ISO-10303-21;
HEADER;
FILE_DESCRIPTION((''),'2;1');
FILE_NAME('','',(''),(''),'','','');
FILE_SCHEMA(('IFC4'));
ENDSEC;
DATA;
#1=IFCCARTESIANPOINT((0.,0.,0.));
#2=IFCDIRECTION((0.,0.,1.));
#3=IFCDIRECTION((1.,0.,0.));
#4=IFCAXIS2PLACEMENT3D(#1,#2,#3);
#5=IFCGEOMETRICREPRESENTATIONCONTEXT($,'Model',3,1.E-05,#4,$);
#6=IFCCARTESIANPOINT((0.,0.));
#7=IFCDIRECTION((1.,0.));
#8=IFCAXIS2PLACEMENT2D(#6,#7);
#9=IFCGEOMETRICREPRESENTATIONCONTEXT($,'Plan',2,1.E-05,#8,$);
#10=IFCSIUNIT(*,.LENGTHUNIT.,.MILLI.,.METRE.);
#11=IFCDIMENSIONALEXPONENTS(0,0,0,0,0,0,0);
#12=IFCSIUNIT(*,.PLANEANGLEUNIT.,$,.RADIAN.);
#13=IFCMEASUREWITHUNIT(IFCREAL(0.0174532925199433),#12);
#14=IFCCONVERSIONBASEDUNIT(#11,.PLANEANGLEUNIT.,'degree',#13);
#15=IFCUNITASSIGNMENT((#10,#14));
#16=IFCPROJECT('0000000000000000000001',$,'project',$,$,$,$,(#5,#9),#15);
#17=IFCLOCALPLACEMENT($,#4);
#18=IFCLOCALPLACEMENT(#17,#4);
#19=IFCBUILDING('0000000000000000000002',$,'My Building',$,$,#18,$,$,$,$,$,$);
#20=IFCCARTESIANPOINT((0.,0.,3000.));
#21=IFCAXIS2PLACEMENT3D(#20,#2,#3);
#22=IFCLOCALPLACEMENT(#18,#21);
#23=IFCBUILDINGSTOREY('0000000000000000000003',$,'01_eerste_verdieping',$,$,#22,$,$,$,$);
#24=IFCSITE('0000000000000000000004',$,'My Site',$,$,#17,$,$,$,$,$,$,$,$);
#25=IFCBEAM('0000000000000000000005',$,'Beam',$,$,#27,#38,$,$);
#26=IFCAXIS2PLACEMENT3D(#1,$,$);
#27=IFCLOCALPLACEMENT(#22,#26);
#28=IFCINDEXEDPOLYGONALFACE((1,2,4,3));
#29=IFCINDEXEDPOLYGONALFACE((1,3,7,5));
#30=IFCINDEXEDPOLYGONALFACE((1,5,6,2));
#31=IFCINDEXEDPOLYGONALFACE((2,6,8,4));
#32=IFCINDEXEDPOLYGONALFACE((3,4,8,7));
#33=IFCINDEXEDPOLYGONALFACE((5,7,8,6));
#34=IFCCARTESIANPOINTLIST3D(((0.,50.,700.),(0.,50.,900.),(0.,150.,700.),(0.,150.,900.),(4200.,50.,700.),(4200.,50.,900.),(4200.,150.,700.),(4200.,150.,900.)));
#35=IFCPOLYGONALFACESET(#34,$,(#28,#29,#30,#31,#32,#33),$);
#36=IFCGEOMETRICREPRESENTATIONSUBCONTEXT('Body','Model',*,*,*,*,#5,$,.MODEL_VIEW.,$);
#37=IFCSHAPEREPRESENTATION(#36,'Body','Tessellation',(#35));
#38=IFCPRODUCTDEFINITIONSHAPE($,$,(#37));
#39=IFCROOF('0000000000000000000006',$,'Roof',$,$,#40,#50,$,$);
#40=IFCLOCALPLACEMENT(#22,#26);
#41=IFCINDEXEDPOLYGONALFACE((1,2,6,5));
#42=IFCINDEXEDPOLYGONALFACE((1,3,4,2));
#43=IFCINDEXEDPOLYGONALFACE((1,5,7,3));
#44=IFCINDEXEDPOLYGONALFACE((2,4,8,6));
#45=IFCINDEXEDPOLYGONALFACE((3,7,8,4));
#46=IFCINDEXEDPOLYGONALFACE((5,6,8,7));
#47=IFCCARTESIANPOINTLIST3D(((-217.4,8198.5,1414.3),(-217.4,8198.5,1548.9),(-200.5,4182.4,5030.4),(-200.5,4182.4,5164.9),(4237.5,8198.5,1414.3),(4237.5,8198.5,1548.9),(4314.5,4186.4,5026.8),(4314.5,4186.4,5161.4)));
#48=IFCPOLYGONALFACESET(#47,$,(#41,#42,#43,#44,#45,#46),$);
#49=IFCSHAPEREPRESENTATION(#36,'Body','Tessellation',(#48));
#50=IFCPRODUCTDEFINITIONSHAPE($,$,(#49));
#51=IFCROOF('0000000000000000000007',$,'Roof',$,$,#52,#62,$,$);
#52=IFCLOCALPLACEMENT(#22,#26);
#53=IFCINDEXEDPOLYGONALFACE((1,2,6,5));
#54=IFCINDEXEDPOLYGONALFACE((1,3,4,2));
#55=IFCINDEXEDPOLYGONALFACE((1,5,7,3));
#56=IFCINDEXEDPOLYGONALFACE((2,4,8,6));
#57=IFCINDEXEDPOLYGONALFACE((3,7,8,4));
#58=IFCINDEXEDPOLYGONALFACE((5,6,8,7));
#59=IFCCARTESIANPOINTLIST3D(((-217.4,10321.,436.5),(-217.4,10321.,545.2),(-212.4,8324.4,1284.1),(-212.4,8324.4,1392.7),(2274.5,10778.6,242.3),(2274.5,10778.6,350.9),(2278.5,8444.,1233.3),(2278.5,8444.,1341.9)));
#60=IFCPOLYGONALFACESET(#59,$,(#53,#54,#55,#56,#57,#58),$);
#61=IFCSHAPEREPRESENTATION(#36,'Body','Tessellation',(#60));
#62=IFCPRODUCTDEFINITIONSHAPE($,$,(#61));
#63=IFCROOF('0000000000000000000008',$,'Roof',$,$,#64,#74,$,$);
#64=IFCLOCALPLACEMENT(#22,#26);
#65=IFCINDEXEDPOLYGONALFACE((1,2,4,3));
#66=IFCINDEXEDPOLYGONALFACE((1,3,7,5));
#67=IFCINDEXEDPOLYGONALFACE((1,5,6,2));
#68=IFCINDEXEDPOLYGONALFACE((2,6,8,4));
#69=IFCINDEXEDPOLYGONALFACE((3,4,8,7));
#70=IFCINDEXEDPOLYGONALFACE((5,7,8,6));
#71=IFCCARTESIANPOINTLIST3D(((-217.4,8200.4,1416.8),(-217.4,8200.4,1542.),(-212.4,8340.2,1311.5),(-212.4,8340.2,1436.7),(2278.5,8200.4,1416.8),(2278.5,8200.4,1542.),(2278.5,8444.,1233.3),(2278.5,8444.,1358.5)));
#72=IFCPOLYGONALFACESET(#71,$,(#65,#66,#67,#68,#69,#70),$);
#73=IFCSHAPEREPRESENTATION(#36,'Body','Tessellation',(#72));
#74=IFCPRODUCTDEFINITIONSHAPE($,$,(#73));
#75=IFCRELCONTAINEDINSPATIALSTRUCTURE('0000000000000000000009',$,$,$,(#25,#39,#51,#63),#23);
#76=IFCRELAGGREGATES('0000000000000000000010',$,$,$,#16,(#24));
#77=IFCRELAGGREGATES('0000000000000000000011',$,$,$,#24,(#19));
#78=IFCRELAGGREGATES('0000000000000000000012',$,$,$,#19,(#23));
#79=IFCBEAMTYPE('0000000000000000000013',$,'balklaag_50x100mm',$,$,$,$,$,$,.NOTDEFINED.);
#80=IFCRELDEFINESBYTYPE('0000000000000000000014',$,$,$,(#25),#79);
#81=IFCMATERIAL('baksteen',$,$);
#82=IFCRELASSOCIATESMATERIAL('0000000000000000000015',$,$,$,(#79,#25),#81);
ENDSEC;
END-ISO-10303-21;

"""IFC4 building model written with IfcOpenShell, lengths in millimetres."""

from ifc_helpers import new_model, entity, si_unit, converted_unit, frame, origin_with_axes, origin_2d_with_axis, place, context, subcontext, project, spatial, line, indexed_curve, rectangle, outline, extrude, material, material_profile, profile_set, profile_usage, type_object, element, save


model = new_model("IFC4")

# Units and contexts
model_context = context("Model", 3, precision=1e-05, world=origin_with_axes())
plan_context = context("Plan", 2, precision=1e-05, world=origin_2d_with_axis())
body_context = subcontext(model_context, "Body", "Model", "MODEL_VIEW")
ifc_project = project(units=[si_unit("LENGTHUNIT", "METRE", prefix="MILLI"), converted_unit("PLANEANGLEUNIT", "degree", entity("IfcReal", 0.0174532925199433), si_unit("PLANEANGLEUNIT", "RADIAN"), dimensions=[0, 0, 0, 0, 0, 0, 0])], contexts=[model_context, plan_context])

# Site, building, storey
site_placement = place(None, origin_with_axes())
site = spatial("IfcSite", under=ifc_project, at=site_placement, Name="My Site")
building_placement = place(site_placement, origin_with_axes())
building = spatial("IfcBuilding", under=site, at=building_placement, Name="My Building")
storey_placement = place(building_placement, frame((0.0, 0.0, 3000.0), z_axis=(0.0, 0.0, 1.0), x_axis=(1.0, 0.0, 0.0)))
storey = spatial("IfcBuildingStorey", under=building, at=storey_placement, Name="01_eerste_verdieping")

# Beam
ifc_material = material(Name="baksteen")
ifc_material_profile_1 = material_profile(ifc_material, rectangle(XDim=100.0, YDim=200.0))
ifc_profile_set_1 = profile_set([ifc_material_profile_1])
beam_type_1 = type_object("IfcBeamType", Name="balklaag_50x100mm", PredefinedType="NOTDEFINED", material=ifc_profile_set_1)
ifc_profile_usage_1 = profile_usage(ifc_profile_set_1, cardinal=5)
beam_1_placement = place(storey_placement, frame((4200.0, 100.0, 800.0), z_axis=(-1.0, 0.0, 0.0), x_axis=(0.0, -1.0, 0.0)))
element("IfcBeam", 1, at=beam_1_placement, inside=storey, type_object=beam_type_1, material=ifc_profile_usage_1, Name="Beam", context=body_context, shape_type="SweptSolid", body=[
    extrude(rectangle(XDim=100.0, YDim=200.0), origin_with_axes(), (0.0, 0.0, 1.0), 4200.0),
])

# Roofs
roof_1_placement = place(storey_placement, frame((4237.5, 8198.5, 1414.3), z_axis=(0.0, 0.669131, 0.743145), x_axis=(-1.0, 0.0, 0.0)))
element("IfcRoof", 2, at=roof_1_placement, inside=storey, Name="Roof", context=body_context, shape_type="SweptSolid", body=[
    extrude(outline(indexed_curve([(0.0, 0.0), (4455.0, 0.0), (4438.0, 5404.1), (-77.0, 5398.9)], segments=[line(3, 2), line(2, 1), line(1, 4), line(4, 3)], self_intersect=False)), None, (0.0, 0.669131, 0.743145), 134.6),
])
roof_2_placement = place(storey_placement, frame((2274.5, 10778.6, 242.3), z_axis=(0.0, 0.390731, 0.920505), x_axis=(-1.0, 0.0, 0.0)))
element("IfcRoof", 3, at=roof_2_placement, inside=storey, Name="Roof", context=body_context, shape_type="SweptSolid", body=[
    extrude(outline(indexed_curve([(-4.0, 2536.2), (0.0, 0.0), (2491.9, 497.1), (2486.9, 2666.2)], segments=[line(4, 1), line(1, 2), line(2, 3), line(3, 4)], self_intersect=False)), None, (0.0, 0.390731, 0.920505), 108.6),
])
roof_3_placement = place(storey_placement, frame((2278.5, 8444.0, 1233.3), z_axis=(0.0, 0.601815, 0.798636), x_axis=(-1.0, 0.0, 0.0)))
element("IfcRoof", 4, at=roof_3_placement, inside=storey, Name="Roof", context=body_context, shape_type="SweptSolid", body=[
    extrude(outline(indexed_curve([(0.0, 305.0), (2496.0, 305.0), (2491.0, 129.9), (0.0, 0.0)], segments=[line(4, 1), line(1, 2), line(2, 3), line(3, 4)], self_intersect=False)), None, (0.0, 0.601815, 0.798636), 125.2),
])

save(model, "model.ifc")
